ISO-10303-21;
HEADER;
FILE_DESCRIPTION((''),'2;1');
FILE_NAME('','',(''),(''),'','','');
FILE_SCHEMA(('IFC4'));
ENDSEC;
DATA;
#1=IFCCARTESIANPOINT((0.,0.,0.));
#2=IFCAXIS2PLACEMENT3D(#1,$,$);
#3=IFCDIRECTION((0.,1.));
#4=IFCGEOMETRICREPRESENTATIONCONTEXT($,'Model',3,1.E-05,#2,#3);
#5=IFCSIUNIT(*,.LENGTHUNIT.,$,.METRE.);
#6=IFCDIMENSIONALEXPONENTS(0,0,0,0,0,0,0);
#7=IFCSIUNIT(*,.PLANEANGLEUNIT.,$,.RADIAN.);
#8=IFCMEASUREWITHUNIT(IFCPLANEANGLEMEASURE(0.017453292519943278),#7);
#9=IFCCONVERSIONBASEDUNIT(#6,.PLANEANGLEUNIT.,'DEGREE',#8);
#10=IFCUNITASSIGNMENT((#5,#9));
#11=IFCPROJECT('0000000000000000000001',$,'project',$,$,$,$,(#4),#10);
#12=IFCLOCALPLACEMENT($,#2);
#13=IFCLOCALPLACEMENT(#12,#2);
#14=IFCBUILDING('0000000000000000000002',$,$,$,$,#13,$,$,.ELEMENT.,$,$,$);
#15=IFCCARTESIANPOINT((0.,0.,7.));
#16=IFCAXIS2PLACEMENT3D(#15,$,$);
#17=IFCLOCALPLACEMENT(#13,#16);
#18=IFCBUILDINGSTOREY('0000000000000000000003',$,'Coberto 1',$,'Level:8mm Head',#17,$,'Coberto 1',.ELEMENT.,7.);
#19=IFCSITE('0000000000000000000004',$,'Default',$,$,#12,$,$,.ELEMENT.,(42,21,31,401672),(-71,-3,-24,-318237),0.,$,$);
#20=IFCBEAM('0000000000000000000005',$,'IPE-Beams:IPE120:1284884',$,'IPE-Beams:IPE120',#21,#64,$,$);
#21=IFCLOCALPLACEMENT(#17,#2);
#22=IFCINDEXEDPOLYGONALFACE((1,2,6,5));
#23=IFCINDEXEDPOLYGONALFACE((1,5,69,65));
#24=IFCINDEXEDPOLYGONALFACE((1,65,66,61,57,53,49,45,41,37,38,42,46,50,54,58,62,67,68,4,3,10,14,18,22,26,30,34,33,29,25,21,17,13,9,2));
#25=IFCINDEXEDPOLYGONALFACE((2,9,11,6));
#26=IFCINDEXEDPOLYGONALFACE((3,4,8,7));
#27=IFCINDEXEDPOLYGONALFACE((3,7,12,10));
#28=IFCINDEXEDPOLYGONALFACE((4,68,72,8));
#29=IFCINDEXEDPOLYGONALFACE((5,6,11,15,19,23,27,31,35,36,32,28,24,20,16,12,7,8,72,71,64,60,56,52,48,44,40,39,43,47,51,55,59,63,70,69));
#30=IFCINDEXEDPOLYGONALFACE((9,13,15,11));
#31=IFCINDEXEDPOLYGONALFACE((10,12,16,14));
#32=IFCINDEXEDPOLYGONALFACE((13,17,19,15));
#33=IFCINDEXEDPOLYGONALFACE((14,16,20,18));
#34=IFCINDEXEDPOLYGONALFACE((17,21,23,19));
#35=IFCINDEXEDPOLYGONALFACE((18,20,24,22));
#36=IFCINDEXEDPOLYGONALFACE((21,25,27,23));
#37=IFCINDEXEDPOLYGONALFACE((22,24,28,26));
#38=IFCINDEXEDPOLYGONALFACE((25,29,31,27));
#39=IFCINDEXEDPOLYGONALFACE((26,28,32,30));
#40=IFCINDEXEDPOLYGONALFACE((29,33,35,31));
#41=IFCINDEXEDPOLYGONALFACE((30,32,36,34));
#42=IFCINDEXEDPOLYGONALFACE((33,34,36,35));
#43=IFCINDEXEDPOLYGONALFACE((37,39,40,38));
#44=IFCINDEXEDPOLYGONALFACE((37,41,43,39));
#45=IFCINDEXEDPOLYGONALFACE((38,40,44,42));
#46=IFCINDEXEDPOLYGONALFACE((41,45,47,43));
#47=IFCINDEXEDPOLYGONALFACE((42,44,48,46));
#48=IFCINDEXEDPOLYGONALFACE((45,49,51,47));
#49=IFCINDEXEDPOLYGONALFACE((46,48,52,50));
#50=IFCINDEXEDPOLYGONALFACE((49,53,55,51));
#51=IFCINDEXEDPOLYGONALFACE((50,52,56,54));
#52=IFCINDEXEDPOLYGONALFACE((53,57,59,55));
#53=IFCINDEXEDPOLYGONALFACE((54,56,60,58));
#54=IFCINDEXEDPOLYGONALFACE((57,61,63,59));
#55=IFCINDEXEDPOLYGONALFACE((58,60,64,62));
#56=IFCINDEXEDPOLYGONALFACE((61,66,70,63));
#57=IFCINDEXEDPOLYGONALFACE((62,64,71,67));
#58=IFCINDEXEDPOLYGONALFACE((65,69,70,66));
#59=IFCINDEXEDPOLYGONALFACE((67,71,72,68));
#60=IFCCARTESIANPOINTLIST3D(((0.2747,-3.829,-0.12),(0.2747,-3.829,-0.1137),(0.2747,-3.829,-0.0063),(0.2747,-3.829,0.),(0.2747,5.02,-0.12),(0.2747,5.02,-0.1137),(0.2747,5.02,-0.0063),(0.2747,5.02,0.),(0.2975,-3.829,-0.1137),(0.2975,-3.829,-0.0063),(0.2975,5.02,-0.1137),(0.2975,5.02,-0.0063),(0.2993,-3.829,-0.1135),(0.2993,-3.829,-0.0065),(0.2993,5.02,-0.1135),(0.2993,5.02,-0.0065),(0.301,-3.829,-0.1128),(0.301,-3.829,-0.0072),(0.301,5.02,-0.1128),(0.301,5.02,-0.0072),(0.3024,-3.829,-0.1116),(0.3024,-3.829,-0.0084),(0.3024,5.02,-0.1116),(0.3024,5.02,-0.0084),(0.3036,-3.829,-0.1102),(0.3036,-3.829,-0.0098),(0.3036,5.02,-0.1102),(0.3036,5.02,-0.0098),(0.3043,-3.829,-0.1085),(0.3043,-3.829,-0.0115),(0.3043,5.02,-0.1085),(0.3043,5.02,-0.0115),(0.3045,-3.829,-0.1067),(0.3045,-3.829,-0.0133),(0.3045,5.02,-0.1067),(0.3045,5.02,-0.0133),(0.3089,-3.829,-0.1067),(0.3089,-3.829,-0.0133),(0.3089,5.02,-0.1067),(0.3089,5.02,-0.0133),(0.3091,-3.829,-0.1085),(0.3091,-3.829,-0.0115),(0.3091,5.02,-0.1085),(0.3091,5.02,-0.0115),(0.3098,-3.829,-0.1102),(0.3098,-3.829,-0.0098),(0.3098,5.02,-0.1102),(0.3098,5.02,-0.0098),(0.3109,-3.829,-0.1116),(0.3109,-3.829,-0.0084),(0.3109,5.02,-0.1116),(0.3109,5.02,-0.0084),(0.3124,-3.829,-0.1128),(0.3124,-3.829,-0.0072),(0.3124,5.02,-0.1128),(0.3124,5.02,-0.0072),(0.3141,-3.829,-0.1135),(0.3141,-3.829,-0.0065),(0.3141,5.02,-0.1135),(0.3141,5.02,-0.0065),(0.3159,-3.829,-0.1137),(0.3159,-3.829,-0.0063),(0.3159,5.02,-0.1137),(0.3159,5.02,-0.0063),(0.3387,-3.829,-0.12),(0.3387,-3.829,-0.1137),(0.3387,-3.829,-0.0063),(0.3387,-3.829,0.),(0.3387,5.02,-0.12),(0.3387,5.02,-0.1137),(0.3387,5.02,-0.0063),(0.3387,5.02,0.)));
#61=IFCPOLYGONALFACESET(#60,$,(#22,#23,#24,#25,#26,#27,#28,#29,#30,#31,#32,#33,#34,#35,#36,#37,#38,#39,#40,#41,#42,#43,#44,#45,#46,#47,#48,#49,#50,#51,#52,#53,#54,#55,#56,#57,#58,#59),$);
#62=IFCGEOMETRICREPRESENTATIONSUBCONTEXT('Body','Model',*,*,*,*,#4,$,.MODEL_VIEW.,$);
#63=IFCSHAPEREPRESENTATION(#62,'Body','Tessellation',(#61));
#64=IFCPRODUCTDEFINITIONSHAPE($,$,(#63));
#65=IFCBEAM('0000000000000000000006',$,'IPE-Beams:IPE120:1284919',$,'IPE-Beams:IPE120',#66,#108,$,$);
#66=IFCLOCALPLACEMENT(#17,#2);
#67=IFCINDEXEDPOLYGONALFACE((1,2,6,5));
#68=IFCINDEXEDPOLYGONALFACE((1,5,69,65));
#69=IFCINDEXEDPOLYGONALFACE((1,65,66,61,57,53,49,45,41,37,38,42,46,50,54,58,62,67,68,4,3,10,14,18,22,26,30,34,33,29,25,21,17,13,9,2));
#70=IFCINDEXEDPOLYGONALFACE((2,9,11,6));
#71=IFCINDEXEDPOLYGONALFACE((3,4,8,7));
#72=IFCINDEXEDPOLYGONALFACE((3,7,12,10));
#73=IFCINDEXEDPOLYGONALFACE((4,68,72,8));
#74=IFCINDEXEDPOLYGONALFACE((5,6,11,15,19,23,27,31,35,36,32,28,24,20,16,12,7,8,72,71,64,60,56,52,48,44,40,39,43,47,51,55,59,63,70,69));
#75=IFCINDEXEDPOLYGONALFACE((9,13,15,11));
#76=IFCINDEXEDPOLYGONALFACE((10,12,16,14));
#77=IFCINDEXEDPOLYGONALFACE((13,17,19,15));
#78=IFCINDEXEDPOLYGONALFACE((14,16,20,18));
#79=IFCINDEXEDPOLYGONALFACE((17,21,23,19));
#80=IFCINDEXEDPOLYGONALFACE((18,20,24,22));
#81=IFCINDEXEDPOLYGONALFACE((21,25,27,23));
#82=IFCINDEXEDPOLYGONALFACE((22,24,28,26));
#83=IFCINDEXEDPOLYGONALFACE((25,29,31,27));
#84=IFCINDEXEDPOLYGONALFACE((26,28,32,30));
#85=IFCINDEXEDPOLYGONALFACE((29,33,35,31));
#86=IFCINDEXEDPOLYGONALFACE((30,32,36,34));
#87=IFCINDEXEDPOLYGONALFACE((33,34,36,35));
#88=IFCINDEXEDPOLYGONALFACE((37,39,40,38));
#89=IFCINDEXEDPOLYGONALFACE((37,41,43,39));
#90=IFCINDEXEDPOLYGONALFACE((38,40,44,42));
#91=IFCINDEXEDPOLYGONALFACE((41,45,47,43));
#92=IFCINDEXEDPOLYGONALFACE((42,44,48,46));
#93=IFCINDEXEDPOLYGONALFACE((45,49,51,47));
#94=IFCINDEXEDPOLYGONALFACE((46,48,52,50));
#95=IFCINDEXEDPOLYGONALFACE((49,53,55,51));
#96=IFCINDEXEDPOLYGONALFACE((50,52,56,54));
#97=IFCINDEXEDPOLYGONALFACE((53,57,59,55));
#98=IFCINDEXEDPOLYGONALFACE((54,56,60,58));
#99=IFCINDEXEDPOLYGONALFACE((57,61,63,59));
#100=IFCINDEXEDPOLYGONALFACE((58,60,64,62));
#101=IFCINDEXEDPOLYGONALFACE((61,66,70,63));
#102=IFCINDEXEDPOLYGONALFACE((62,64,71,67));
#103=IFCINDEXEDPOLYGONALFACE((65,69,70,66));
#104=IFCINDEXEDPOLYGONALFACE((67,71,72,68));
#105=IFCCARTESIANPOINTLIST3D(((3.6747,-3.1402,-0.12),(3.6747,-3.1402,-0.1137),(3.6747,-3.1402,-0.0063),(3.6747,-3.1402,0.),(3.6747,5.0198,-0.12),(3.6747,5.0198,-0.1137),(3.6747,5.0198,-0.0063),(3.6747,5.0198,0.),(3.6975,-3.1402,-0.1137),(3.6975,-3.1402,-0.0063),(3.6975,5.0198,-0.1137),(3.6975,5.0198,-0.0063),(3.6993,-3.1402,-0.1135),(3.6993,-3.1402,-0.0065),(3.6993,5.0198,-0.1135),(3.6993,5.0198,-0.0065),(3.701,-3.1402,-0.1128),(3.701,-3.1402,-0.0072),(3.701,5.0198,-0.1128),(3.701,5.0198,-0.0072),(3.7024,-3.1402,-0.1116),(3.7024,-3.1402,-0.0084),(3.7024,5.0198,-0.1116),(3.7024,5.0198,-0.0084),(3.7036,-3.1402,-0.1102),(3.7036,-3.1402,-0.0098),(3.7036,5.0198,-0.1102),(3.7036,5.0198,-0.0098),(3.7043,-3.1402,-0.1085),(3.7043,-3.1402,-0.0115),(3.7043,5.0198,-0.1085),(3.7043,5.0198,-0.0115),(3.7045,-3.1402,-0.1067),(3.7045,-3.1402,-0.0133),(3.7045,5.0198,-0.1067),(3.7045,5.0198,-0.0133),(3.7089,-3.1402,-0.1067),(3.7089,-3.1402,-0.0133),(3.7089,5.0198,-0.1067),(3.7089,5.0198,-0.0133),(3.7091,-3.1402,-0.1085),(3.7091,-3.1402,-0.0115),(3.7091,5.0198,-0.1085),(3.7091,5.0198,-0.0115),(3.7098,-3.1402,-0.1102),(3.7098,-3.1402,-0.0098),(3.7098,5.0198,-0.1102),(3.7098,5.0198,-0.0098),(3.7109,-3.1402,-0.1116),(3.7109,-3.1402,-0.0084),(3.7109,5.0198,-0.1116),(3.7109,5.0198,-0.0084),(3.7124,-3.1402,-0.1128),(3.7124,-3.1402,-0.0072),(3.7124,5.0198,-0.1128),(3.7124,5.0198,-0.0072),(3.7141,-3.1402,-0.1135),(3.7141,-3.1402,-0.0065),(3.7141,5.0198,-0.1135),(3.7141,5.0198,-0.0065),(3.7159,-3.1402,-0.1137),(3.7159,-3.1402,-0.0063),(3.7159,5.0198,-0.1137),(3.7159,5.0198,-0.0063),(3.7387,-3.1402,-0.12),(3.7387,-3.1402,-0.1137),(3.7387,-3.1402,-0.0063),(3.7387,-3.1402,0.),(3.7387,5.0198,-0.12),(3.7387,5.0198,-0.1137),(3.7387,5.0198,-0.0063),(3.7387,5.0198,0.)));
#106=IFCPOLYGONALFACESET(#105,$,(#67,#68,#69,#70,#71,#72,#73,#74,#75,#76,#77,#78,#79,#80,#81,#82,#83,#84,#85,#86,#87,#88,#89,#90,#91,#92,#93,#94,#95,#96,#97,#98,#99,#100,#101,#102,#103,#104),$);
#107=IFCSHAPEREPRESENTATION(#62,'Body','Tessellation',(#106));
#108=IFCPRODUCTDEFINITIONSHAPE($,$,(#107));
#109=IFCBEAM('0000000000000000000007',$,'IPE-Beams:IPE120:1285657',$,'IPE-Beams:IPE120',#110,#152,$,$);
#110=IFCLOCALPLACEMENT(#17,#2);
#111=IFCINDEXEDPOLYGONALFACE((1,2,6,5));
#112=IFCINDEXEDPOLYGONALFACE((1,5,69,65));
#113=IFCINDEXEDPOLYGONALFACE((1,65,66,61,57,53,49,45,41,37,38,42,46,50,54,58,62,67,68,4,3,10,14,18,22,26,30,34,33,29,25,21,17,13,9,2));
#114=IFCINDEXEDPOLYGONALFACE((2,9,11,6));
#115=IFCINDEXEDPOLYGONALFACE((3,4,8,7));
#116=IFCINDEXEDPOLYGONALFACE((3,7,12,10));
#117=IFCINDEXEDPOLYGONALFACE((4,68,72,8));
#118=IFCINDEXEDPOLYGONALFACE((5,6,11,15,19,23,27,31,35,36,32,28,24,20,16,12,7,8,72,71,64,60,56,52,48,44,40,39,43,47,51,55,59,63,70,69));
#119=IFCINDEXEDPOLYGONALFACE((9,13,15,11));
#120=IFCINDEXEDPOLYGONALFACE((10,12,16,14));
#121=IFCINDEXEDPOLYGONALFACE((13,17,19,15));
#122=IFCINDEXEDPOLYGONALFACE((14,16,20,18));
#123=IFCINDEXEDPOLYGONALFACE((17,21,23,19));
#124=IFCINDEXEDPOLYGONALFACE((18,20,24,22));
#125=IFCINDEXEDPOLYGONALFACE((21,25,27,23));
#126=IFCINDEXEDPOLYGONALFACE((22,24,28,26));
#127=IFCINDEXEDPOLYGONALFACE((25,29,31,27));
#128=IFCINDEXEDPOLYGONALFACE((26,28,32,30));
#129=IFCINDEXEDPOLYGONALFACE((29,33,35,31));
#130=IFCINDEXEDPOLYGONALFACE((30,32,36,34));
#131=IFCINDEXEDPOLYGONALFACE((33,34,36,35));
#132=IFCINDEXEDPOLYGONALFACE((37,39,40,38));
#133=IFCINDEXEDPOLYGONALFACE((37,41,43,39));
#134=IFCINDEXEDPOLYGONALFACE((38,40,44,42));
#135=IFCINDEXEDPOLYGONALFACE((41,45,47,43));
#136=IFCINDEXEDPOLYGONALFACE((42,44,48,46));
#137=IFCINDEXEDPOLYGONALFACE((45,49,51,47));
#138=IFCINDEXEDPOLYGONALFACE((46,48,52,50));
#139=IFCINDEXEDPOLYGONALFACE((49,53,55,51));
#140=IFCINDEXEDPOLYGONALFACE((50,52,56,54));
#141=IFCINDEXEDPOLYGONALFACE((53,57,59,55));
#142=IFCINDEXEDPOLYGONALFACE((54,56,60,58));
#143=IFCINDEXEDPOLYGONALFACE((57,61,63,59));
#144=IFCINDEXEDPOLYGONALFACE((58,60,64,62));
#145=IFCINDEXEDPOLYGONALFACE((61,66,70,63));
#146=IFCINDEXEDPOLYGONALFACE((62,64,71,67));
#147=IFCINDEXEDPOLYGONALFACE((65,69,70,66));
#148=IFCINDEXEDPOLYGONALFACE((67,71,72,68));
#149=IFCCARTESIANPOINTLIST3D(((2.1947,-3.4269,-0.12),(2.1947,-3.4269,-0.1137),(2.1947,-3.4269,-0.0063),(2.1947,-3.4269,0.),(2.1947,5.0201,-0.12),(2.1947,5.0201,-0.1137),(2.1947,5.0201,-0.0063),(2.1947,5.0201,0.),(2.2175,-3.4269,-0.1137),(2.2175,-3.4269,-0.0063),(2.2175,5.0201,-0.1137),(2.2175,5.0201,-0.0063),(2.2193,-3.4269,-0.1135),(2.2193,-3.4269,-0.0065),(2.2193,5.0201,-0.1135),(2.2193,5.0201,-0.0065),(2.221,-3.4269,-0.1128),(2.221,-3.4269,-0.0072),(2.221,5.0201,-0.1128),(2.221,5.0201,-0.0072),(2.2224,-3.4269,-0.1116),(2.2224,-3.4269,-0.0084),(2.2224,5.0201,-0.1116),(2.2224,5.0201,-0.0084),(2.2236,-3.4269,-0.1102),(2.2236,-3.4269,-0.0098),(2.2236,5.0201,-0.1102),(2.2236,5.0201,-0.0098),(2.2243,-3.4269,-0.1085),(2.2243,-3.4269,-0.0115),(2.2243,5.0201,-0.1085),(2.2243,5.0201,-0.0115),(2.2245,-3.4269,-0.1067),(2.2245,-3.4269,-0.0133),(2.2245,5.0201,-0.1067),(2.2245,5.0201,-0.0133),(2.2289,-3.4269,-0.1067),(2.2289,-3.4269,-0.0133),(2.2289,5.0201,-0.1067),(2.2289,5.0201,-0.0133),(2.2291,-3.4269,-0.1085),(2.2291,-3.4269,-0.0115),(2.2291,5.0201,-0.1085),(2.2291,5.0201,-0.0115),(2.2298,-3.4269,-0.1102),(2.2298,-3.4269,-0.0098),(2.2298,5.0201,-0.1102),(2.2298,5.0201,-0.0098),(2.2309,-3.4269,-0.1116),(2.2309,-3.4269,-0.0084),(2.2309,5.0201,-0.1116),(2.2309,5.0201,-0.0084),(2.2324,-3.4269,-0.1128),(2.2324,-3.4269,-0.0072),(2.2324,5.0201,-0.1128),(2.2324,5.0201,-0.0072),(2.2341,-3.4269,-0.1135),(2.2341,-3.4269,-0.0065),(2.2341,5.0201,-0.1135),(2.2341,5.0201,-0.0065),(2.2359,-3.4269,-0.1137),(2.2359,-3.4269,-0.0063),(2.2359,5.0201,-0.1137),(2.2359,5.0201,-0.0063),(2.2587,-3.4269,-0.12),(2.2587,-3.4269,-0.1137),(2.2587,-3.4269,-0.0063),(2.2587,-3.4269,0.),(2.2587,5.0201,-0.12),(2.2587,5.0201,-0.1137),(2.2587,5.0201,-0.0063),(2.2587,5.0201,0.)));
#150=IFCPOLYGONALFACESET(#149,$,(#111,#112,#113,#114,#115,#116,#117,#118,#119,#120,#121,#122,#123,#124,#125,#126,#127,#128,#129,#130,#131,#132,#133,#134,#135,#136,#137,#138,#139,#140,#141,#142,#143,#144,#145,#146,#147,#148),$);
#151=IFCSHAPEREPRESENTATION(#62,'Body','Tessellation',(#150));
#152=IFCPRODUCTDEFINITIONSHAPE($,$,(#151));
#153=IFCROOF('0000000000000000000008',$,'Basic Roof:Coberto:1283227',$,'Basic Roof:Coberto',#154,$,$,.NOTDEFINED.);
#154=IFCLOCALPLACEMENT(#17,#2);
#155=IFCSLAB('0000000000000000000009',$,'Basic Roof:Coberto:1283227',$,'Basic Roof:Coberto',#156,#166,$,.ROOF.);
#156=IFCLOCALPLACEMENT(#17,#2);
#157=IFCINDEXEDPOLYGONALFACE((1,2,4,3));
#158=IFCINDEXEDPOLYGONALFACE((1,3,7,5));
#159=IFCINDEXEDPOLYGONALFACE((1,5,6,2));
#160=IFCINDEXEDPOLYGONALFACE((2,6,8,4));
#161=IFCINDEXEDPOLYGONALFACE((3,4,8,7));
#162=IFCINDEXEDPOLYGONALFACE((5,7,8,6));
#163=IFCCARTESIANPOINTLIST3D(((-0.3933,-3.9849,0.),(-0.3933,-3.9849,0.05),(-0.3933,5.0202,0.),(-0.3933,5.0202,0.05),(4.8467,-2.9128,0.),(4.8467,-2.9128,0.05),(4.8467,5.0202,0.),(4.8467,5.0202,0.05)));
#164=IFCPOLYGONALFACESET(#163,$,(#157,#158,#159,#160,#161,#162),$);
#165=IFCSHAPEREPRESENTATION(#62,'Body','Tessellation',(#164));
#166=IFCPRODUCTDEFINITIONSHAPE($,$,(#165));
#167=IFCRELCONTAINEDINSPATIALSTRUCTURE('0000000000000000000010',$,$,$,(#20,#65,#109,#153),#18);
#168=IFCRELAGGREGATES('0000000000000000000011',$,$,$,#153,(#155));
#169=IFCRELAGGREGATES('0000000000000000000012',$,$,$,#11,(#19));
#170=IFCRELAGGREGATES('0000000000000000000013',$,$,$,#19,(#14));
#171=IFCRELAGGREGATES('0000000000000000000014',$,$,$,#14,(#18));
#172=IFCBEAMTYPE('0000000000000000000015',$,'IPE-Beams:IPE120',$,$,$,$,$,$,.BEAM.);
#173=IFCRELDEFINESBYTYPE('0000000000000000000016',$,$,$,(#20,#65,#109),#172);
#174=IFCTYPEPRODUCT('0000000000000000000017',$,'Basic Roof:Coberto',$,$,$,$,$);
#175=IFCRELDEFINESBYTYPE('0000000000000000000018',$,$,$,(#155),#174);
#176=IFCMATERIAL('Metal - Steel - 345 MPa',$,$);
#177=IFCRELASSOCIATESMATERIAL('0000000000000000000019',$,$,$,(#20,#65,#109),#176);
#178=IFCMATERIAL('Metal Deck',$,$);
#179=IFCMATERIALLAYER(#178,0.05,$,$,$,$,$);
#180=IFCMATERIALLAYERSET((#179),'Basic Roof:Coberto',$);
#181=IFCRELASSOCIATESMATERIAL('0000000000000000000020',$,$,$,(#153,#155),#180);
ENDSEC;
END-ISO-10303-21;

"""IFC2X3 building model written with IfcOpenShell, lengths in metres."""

from ifc_helpers import new_model, entity, si_unit, converted_unit, direction, frame, frame_2d, origin, place, context, subcontext, project, spatial, polyline, circle_curve, parameter, trimmed, segment, composite_curve, i_section, outline, extrude, material, layer, layer_set, type_object, element, aggregate, save


model = new_model("IFC2X3")

# Units and contexts
model_context = context("Model", 3, precision=1e-05, world=origin(), true_north=direction((0.0, 1.0)))
body_context = subcontext(model_context, "Body", "Model", "MODEL_VIEW")
ifc_project = project(units=[si_unit("LENGTHUNIT", "METRE"), converted_unit("PLANEANGLEUNIT", "DEGREE", entity("IfcPlaneAngleMeasure", 0.017453292519943278), si_unit("PLANEANGLEUNIT", "RADIAN"), dimensions=[0, 0, 0, 0, 0, 0, 0])], contexts=[model_context])

# Site, building, storey
site_placement = place(None, origin())
site = spatial("IfcSite", under=ifc_project, at=site_placement, Name="Default", CompositionType="ELEMENT", RefLatitude=(42, 21, 31, 401672), RefLongitude=(-71, -3, -24, -318237), RefElevation=0.0)
building_placement = place(site_placement, origin())
building = spatial("IfcBuilding", under=site, at=building_placement, CompositionType="ELEMENT")
storey_placement = place(building_placement, frame((0.0, 0.0, 7.0)))
storey = spatial("IfcBuildingStorey", under=building, at=storey_placement, Name="Coberto 1", ObjectType="Level:8mm Head", LongName="Coberto 1", CompositionType="ELEMENT", Elevation=7.0)

# Shared definitions
ifc_material_1 = material(Name="Metal - Steel - 345 MPa")

# Beams
beam_type_1 = type_object("IfcBeamType", Name="IPE-Beams:IPE120", PredefinedType="BEAM")
beam_1_placement = place(storey_placement, frame((0.2747, 5.0202, 0.0), z_axis=(0.0, 0.0, 1.0), x_axis=(0.0, -1.0, 0.0)))
element("IfcBeam", 1, at=beam_1_placement, inside=storey, type_object=beam_type_1, material=ifc_material_1, Name="IPE-Beams:IPE120:1284884", ObjectType="IPE-Beams:IPE120", context=body_context, shape_type="SweptSolid", body=[
    extrude(outline(composite_curve([segment(polyline([(0.0537, -0.032), (0.06, -0.032)]), True, "CONTINUOUS"), segment(polyline([(0.06, -0.032), (0.06, 0.032)]), True, "CONTINUOUS"), segment(polyline([(0.06, 0.032), (0.0537, 0.032)]), True, "CONTINUOUS"), segment(polyline([(0.0537, 0.032), (0.0537, 0.0092)]), True, "CONTINUOUS"), segment(trimmed(circle_curve(frame_2d((0.0467, 0.0092), x_axis=(1.0, 0.0)), 0.007), [parameter(270.0)], [parameter(0.0)], True, "PARAMETER"), False, "CONTINUOUS"), segment(polyline([(0.0467, 0.0022), (-0.0467, 0.0022)]), True, "CONTINUOUS"), segment(trimmed(circle_curve(frame_2d((-0.0467, 0.0092), x_axis=(0.0, -1.0)), 0.007), [parameter(270.0)], [parameter(0.0)], True, "PARAMETER"), False, "CONTINUOUS"), segment(polyline([(-0.0537, 0.0092), (-0.0537, 0.032)]), True, "CONTINUOUS"), segment(polyline([(-0.0537, 0.032), (-0.06, 0.032)]), True, "CONTINUOUS"), segment(polyline([(-0.06, 0.032), (-0.06, -0.032)]), True, "CONTINUOUS"), segment(polyline([(-0.06, -0.032), (-0.0537, -0.032)]), True, "CONTINUOUS"), segment(polyline([(-0.0537, -0.032), (-0.0537, -0.0092)]), True, "CONTINUOUS"), segment(trimmed(circle_curve(frame_2d((-0.0467, -0.0092), x_axis=(-1.0, 0.0)), 0.007), [parameter(270.0)], [parameter(0.0)], True, "PARAMETER"), False, "CONTINUOUS"), segment(polyline([(-0.0467, -0.0022), (0.0467, -0.0022)]), True, "CONTINUOUS"), segment(trimmed(circle_curve(frame_2d((0.0467, -0.0092), x_axis=(0.0, 1.0)), 0.007), [parameter(270.0)], [parameter(0.0)], True, "PARAMETER"), False, "CONTINUOUS"), segment(polyline([(0.0537, -0.0092), (0.0537, -0.032)]), True, "CONTINUOUS")], self_intersect=False)), frame((0.0002, 0.032, -0.06), z_axis=(1.0, 0.0, 0.0), x_axis=(0.0, 0.0, -1.0)), (0.0, 0.0, 1.0), 8.849),
])
beam_2_placement = place(storey_placement, frame((3.7387, 5.0202, 0.0), z_axis=(0.0, 0.0, 1.0), x_axis=(0.0, -1.0, 0.0)))
element("IfcBeam", 2, at=beam_2_placement, inside=storey, type_object=beam_type_1, material=ifc_material_1, Name="IPE-Beams:IPE120:1284919", ObjectType="IPE-Beams:IPE120", context=body_context, shape_type="SweptSolid", body=[
    extrude(i_section(OverallWidth=0.064, OverallDepth=0.12, WebThickness=0.0044, FlangeThickness=0.0063, FilletRadius=0.007, at=frame_2d((0.0, 0.0), x_axis=(0.0, 1.0))), frame((0.0004, -0.032, -0.06), z_axis=(1.0, 0.0, 0.0), x_axis=(0.0, 0.0, -1.0)), (0.0, 0.0, 1.0), 8.16),
])
beam_3_placement = place(storey_placement, frame((2.2267, 5.0202, 0.0), z_axis=(0.0, 0.0, 1.0), x_axis=(0.0, -1.0, 0.0)))
element("IfcBeam", 3, at=beam_3_placement, inside=storey, type_object=beam_type_1, material=ifc_material_1, Name="IPE-Beams:IPE120:1285657", ObjectType="IPE-Beams:IPE120", context=body_context, shape_type="SweptSolid", body=[
    extrude(i_section(OverallWidth=0.064, OverallDepth=0.12, WebThickness=0.0044, FlangeThickness=0.0063, FilletRadius=0.007, at=frame_2d((0.0, 0.0), x_axis=(0.0, 1.0))), frame((0.0, 0.0, -0.06), z_axis=(1.0, 0.0, 0.0), x_axis=(0.0, 0.0, -1.0)), (0.0, 0.0, 1.0), 8.447),
])

# Roof, slab
ifc_material_2 = material(Name="Metal Deck")
ifc_layer = layer(ifc_material_2, 0.05)
ifc_layer_set = layer_set([ifc_layer], Name="Basic Roof:Coberto")
roof_placement = place(storey_placement, frame((-0.3933, -3.9849, 0.0)))
roof = element("IfcRoof", 4, at=roof_placement, inside=storey, material=ifc_layer_set, Name="Basic Roof:Coberto:1283227", ObjectType="Basic Roof:Coberto", ShapeType="NOTDEFINED")
type_product = type_object("IfcTypeProduct", Name="Basic Roof:Coberto")
slab_placement = place(roof_placement, origin())
slab = element("IfcSlab", 5, at=slab_placement, type_object=type_product, material=ifc_layer_set, Name="Basic Roof:Coberto:1283227", ObjectType="Basic Roof:Coberto", PredefinedType="ROOF", context=body_context, shape_type="SweptSolid", body=[
    extrude(outline(polyline([(-2.62, -4.5026), (2.62, -3.4305), (2.62, 4.5026), (-2.62, 4.5026), (-2.62, -4.5026)])), frame((2.62, 4.5026, 0.0)), (0.0, 0.0, 1.0), 0.05),
])
aggregate(roof, [slab])

save(model, "model.ifc")
